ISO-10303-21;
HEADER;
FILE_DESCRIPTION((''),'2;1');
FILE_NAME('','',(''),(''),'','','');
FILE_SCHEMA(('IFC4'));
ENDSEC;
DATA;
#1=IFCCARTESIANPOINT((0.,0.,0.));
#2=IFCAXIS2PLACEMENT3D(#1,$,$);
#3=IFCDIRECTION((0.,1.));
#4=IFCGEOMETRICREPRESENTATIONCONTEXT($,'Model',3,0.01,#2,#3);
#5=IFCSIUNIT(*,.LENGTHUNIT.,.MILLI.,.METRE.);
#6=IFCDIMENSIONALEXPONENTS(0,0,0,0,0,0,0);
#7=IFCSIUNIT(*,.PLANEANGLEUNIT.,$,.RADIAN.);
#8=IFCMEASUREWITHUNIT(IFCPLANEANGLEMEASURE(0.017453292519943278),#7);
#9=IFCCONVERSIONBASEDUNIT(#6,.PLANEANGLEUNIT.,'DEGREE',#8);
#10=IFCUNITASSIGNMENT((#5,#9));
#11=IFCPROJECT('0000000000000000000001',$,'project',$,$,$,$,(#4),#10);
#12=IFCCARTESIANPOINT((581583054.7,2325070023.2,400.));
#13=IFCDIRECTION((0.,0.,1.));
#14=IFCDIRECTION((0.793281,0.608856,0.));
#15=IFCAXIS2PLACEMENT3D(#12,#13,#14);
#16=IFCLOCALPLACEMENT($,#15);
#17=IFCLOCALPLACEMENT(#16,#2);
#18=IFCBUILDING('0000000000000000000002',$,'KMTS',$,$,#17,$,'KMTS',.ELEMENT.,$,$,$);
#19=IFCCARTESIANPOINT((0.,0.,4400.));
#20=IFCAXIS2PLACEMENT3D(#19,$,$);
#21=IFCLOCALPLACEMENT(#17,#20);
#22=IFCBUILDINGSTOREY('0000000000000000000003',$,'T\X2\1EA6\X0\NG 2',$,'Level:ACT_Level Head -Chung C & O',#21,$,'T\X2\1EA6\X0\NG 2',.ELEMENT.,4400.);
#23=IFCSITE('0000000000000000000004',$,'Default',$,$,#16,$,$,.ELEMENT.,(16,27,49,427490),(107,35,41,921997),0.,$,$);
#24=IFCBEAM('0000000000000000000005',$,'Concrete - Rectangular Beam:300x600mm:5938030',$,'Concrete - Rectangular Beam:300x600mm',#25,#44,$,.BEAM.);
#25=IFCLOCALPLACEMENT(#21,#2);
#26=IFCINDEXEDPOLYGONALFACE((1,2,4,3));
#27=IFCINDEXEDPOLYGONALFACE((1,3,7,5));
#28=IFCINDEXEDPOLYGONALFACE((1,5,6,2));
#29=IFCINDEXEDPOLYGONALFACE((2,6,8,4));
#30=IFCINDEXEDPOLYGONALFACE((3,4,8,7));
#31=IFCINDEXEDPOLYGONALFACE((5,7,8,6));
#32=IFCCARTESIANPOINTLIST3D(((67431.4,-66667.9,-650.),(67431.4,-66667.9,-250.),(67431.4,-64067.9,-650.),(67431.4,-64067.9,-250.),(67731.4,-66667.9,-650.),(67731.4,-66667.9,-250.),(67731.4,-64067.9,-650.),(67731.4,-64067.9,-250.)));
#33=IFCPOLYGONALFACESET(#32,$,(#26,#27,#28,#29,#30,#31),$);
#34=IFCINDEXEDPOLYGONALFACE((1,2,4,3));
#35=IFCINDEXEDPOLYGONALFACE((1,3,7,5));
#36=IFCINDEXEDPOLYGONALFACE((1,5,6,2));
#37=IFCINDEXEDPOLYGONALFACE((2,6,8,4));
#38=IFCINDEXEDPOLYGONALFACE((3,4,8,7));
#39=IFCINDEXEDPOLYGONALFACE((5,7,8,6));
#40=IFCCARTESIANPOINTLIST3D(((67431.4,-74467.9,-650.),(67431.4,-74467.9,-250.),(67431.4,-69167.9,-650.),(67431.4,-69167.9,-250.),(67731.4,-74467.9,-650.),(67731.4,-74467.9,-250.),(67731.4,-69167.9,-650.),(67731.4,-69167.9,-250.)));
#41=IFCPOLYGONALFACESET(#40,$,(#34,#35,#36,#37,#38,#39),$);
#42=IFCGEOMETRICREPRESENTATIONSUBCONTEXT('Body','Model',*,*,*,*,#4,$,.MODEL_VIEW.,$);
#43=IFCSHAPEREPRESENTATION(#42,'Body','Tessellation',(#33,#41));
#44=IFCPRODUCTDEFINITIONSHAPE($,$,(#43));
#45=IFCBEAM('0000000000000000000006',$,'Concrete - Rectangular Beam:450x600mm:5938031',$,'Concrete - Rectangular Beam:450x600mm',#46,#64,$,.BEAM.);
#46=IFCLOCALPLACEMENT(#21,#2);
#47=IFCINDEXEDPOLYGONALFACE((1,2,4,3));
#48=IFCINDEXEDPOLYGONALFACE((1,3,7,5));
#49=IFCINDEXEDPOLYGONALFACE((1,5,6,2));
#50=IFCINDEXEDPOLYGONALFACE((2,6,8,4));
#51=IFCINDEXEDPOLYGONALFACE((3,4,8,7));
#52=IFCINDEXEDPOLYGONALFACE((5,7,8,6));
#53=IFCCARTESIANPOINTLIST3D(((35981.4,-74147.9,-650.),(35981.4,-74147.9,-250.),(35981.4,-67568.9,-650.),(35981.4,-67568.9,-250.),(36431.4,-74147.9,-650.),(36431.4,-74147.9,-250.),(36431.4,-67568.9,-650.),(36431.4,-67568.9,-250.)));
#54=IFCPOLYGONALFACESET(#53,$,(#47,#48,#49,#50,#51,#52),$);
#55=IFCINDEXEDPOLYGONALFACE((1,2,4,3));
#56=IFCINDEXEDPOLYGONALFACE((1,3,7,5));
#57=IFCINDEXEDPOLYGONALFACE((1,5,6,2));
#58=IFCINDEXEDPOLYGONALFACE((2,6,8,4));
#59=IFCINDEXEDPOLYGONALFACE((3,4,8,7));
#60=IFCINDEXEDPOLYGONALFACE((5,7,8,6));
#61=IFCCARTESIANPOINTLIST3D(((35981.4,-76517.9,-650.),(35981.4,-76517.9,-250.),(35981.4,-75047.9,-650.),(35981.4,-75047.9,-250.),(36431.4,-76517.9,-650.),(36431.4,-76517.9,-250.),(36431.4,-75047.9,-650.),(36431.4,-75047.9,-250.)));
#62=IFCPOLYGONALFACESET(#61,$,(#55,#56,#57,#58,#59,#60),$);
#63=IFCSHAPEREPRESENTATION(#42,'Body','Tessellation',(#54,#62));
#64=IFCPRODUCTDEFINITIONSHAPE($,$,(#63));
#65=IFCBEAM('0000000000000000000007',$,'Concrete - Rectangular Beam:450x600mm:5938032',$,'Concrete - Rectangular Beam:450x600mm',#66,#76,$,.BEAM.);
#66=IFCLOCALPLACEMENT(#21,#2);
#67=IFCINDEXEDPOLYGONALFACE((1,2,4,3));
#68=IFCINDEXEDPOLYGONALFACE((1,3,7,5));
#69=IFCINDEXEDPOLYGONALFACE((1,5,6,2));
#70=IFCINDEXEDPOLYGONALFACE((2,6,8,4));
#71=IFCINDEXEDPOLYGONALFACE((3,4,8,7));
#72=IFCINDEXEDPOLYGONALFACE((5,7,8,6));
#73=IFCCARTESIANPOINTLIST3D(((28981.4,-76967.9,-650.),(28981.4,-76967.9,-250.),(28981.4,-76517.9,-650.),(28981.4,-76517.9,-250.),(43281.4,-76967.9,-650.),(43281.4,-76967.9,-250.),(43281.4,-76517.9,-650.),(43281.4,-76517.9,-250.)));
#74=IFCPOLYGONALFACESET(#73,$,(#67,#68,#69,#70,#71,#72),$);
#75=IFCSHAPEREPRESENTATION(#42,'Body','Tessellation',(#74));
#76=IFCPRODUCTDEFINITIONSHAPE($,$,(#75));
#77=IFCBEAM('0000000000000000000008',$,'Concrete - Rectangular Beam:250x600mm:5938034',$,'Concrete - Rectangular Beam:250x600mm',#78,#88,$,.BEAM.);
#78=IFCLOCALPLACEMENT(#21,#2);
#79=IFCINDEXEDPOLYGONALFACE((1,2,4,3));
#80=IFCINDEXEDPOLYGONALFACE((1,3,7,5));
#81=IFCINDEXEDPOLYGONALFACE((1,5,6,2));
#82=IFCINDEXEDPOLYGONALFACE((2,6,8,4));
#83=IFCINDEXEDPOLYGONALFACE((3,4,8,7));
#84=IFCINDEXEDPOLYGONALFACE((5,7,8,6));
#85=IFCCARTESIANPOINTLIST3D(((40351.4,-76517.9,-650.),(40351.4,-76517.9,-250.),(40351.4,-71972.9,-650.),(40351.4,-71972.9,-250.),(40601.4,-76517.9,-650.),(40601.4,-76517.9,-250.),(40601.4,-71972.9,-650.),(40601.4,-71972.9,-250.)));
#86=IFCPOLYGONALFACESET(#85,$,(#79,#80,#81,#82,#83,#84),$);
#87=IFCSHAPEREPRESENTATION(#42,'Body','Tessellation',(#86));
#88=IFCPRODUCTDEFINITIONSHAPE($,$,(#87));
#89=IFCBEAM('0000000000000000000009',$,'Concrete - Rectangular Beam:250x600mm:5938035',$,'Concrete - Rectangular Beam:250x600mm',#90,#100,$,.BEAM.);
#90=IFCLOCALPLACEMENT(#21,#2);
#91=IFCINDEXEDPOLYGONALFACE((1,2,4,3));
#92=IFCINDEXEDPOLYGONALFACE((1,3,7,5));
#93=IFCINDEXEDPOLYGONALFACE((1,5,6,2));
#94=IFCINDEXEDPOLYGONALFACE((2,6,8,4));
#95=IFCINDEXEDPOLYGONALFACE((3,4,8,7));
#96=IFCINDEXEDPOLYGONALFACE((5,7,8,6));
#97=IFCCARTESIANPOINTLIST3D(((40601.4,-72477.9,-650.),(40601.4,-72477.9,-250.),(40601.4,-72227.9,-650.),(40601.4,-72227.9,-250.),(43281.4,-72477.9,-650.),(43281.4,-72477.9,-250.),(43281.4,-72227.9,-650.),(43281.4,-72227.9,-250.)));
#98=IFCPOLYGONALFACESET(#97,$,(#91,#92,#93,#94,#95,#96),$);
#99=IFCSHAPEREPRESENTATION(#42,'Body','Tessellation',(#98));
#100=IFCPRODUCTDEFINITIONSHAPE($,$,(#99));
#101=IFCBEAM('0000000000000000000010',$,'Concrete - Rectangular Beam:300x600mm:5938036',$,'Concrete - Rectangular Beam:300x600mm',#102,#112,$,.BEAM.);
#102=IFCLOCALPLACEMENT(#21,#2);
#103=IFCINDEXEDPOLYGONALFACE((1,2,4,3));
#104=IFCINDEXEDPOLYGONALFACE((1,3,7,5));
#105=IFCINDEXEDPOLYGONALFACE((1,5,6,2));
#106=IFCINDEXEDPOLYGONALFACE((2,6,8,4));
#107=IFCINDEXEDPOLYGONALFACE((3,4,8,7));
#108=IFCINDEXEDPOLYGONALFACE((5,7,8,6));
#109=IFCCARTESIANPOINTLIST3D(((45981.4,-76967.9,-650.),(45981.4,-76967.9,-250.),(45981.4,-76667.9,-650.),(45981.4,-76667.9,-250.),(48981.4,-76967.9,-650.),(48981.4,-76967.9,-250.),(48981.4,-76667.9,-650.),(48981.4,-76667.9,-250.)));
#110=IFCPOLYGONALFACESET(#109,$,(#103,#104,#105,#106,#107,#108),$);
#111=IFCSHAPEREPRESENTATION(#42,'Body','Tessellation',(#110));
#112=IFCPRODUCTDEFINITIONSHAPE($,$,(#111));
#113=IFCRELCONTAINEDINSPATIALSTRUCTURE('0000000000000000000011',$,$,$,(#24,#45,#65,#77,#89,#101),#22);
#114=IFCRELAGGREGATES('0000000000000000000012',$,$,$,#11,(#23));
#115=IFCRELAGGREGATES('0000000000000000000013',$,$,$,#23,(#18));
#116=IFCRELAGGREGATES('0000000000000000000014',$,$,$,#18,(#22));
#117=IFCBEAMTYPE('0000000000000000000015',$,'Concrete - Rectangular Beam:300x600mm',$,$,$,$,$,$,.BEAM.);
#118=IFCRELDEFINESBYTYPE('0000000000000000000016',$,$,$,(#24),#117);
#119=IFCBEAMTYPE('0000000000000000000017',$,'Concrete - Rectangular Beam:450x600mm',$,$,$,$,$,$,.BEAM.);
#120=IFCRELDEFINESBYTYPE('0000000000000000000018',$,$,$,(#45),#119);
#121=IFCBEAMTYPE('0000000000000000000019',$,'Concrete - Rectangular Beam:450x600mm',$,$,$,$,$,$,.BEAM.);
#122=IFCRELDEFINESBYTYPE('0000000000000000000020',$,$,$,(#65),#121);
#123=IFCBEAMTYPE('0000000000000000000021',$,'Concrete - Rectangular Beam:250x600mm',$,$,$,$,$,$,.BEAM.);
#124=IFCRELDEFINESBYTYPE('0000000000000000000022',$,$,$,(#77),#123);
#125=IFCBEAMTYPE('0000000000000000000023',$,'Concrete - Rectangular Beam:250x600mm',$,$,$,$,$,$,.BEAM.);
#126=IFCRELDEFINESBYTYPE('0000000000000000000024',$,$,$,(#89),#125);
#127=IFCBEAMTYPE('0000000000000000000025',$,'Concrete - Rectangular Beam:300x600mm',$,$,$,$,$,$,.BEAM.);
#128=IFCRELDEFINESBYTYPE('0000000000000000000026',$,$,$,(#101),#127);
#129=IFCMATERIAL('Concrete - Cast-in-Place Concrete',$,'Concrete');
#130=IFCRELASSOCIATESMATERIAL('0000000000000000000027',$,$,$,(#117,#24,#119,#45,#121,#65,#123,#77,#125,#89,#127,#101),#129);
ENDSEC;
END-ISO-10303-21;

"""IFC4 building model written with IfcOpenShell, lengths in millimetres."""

from ifc_helpers import new_model, entity, si_unit, converted_unit, direction, frame, origin, place, context, subcontext, project, spatial, indexed_curve, outline, extrude, source, transform, mapped, material, type_object, type_shapes, element, save


model = new_model("IFC4")

# Units and contexts
model_context = context("Model", 3, precision=0.01, world=origin(), true_north=direction((0.0, 1.0)))
body_context = subcontext(model_context, "Body", "Model", "MODEL_VIEW")
ifc_project = project(units=[si_unit("LENGTHUNIT", "METRE", prefix="MILLI"), converted_unit("PLANEANGLEUNIT", "DEGREE", entity("IfcPlaneAngleMeasure", 0.017453292519943278), si_unit("PLANEANGLEUNIT", "RADIAN"), dimensions=[0, 0, 0, 0, 0, 0, 0])], contexts=[model_context])

# Site, building, storey
site_placement = place(None, frame((581583054.7, 2325070023.2, 400.0), z_axis=(0.0, 0.0, 1.0), x_axis=(0.793281, 0.608856, 0.0)))
site = spatial("IfcSite", under=ifc_project, at=site_placement, Name="Default", CompositionType="ELEMENT", RefLatitude=(16, 27, 49, 427490), RefLongitude=(107, 35, 41, 921997), RefElevation=0.0)
building_placement = place(site_placement, origin())
building = spatial("IfcBuilding", under=site, at=building_placement, Name="KMTS", LongName="KMTS", CompositionType="ELEMENT")
storey_placement = place(building_placement, frame((0.0, 0.0, 4400.0)))
storey = spatial("IfcBuildingStorey", under=building, at=storey_placement, Name="TẦNG 2", ObjectType="Level:ACT_Level Head -Chung C & O", LongName="TẦNG 2", CompositionType="ELEMENT", Elevation=4400.0)

# Beams
ifc_material_1 = material(Name="Concrete - Cast-in-Place Concrete", Category="Concrete")
beam_type_1 = type_object("IfcBeamType", Name="Concrete - Rectangular Beam:300x600mm", PredefinedType="BEAM", material=ifc_material_1)
shared_shape_1 = source(origin(), body_context, "Body", "SweptSolid", [
    extrude(outline(indexed_curve([(-150.0, -200.0), (150.0, -200.0), (150.0, 200.0), (-150.0, 200.0), (-150.0, -200.0)], self_intersect=False)), frame((67581.4, -66667.9, 3950.0), z_axis=(0.0, 1.0, 0.0), x_axis=(-1.0, 0.0, 0.0)), (0.0, 0.0, 1.0), 2600.0),
    extrude(outline(indexed_curve([(-150.0, -200.0), (150.0, -200.0), (150.0, 200.0), (-150.0, 200.0), (-150.0, -200.0)], self_intersect=False)), frame((67581.4, -74467.9, 3950.0), z_axis=(0.0, 1.0, 0.0), x_axis=(-1.0, 0.0, 0.0)), (0.0, 0.0, 1.0), 5300.0),
])
type_shapes(beam_type_1, [shared_shape_1])
beam_1_placement = place(storey_placement, frame((0.0, 0.0, -4400.0)))
element("IfcBeam", 1, at=beam_1_placement, inside=storey, type_object=beam_type_1, material=ifc_material_1, Name="Concrete - Rectangular Beam:300x600mm:5938030", ObjectType="Concrete - Rectangular Beam:300x600mm", PredefinedType="BEAM", context=body_context, shape_type="MappedRepresentation", body=[
    mapped(shared_shape_1, transform((0.0, 0.0, 0.0), scale=1.0)),
])
beam_type_2 = type_object("IfcBeamType", Name="Concrete - Rectangular Beam:450x600mm", PredefinedType="BEAM", material=ifc_material_1)
shared_shape_2 = source(origin(), body_context, "Body", "SweptSolid", [
    extrude(outline(indexed_curve([(-225.0, -200.0), (225.0, -200.0), (225.0, 200.0), (-225.0, 200.0), (-225.0, -200.0)], self_intersect=False)), frame((36206.4, -74147.9, 3950.0), z_axis=(0.0, 1.0, 0.0), x_axis=(-1.0, 0.0, 0.0)), (0.0, 0.0, 1.0), 6579.0),
    extrude(outline(indexed_curve([(-225.0, -200.0), (225.0, -200.0), (225.0, 200.0), (-225.0, 200.0), (-225.0, -200.0)], self_intersect=False)), frame((36206.4, -76517.9, 3950.0), z_axis=(0.0, 1.0, 0.0), x_axis=(-1.0, 0.0, 0.0)), (0.0, 0.0, 1.0), 1470.0),
])
type_shapes(beam_type_2, [shared_shape_2])
beam_2_placement = place(storey_placement, frame((0.0, 0.0, -4400.0)))
element("IfcBeam", 2, at=beam_2_placement, inside=storey, type_object=beam_type_2, material=ifc_material_1, Name="Concrete - Rectangular Beam:450x600mm:5938031", ObjectType="Concrete - Rectangular Beam:450x600mm", PredefinedType="BEAM", context=body_context, shape_type="MappedRepresentation", body=[
    mapped(shared_shape_2, transform((0.0, 0.0, 0.0), scale=1.0)),
])
beam_type_3 = type_object("IfcBeamType", Name="Concrete - Rectangular Beam:450x600mm", PredefinedType="BEAM", material=ifc_material_1)
shared_shape_3 = source(origin(), body_context, "Body", "SweptSolid", [
    extrude(outline(indexed_curve([(-200.0, -225.0), (200.0, -225.0), (200.0, 225.0), (-200.0, 225.0), (-200.0, -225.0)], self_intersect=False)), frame((28981.4, -76742.9, 3950.0), z_axis=(1.0, 0.0, 0.0), x_axis=(0.0, 0.0, -1.0)), (0.0, 0.0, 1.0), 14300.0),
])
type_shapes(beam_type_3, [shared_shape_3])
beam_3_placement = place(storey_placement, frame((0.0, 0.0, -4400.0)))
element("IfcBeam", 3, at=beam_3_placement, inside=storey, type_object=beam_type_3, material=ifc_material_1, Name="Concrete - Rectangular Beam:450x600mm:5938032", ObjectType="Concrete - Rectangular Beam:450x600mm", PredefinedType="BEAM", context=body_context, shape_type="MappedRepresentation", body=[
    mapped(shared_shape_3, transform((0.0, 0.0, 0.0), scale=1.0)),
])
beam_type_4 = type_object("IfcBeamType", Name="Concrete - Rectangular Beam:250x600mm", PredefinedType="BEAM", material=ifc_material_1)
shared_shape_4 = source(origin(), body_context, "Body", "SweptSolid", [
    extrude(outline(indexed_curve([(-125.0, -200.0), (125.0, -200.0), (125.0, 200.0), (-125.0, 200.0), (-125.0, -200.0)], self_intersect=False)), frame((40476.4, -76517.9, 3950.0), z_axis=(0.0, 1.0, 0.0), x_axis=(-1.0, 0.0, 0.0)), (0.0, 0.0, 1.0), 4545.0),
])
type_shapes(beam_type_4, [shared_shape_4])
beam_4_placement = place(storey_placement, frame((0.0, 0.0, -4400.0)))
element("IfcBeam", 4, at=beam_4_placement, inside=storey, type_object=beam_type_4, material=ifc_material_1, Name="Concrete - Rectangular Beam:250x600mm:5938034", ObjectType="Concrete - Rectangular Beam:250x600mm", PredefinedType="BEAM", context=body_context, shape_type="MappedRepresentation", body=[
    mapped(shared_shape_4, transform((0.0, 0.0, 0.0), scale=1.0)),
])
beam_type_5 = type_object("IfcBeamType", Name="Concrete - Rectangular Beam:250x600mm", PredefinedType="BEAM", material=ifc_material_1)
shared_shape_5 = source(origin(), body_context, "Body", "SweptSolid", [
    extrude(outline(indexed_curve([(-200.0, -125.0), (200.0, -125.0), (200.0, 125.0), (-200.0, 125.0), (-200.0, -125.0)], self_intersect=False)), frame((40601.4, -72352.9, 3950.0), z_axis=(1.0, 0.0, 0.0), x_axis=(0.0, 0.0, -1.0)), (0.0, 0.0, 1.0), 2680.0),
])
type_shapes(beam_type_5, [shared_shape_5])
beam_5_placement = place(storey_placement, frame((0.0, 0.0, -4400.0)))
element("IfcBeam", 5, at=beam_5_placement, inside=storey, type_object=beam_type_5, material=ifc_material_1, Name="Concrete - Rectangular Beam:250x600mm:5938035", ObjectType="Concrete - Rectangular Beam:250x600mm", PredefinedType="BEAM", context=body_context, shape_type="MappedRepresentation", body=[
    mapped(shared_shape_5, transform((0.0, 0.0, 0.0), scale=1.0)),
])
beam_type_6 = type_object("IfcBeamType", Name="Concrete - Rectangular Beam:300x600mm", PredefinedType="BEAM", material=ifc_material_1)
shared_shape_6 = source(origin(), body_context, "Body", "SweptSolid", [
    extrude(outline(indexed_curve([(-200.0, -150.0), (200.0, -150.0), (200.0, 150.0), (-200.0, 150.0), (-200.0, -150.0)], self_intersect=False)), frame((45981.4, -76817.9, 3950.0), z_axis=(1.0, 0.0, 0.0), x_axis=(0.0, 0.0, -1.0)), (0.0, 0.0, 1.0), 3000.0),
])
type_shapes(beam_type_6, [shared_shape_6])
beam_6_placement = place(storey_placement, frame((0.0, 0.0, -4400.0)))
element("IfcBeam", 6, at=beam_6_placement, inside=storey, type_object=beam_type_6, material=ifc_material_1, Name="Concrete - Rectangular Beam:300x600mm:5938036", ObjectType="Concrete - Rectangular Beam:300x600mm", PredefinedType="BEAM", context=body_context, shape_type="MappedRepresentation", body=[
    mapped(shared_shape_6, transform((0.0, 0.0, 0.0), scale=1.0)),
])

save(model, "model.ifc")
